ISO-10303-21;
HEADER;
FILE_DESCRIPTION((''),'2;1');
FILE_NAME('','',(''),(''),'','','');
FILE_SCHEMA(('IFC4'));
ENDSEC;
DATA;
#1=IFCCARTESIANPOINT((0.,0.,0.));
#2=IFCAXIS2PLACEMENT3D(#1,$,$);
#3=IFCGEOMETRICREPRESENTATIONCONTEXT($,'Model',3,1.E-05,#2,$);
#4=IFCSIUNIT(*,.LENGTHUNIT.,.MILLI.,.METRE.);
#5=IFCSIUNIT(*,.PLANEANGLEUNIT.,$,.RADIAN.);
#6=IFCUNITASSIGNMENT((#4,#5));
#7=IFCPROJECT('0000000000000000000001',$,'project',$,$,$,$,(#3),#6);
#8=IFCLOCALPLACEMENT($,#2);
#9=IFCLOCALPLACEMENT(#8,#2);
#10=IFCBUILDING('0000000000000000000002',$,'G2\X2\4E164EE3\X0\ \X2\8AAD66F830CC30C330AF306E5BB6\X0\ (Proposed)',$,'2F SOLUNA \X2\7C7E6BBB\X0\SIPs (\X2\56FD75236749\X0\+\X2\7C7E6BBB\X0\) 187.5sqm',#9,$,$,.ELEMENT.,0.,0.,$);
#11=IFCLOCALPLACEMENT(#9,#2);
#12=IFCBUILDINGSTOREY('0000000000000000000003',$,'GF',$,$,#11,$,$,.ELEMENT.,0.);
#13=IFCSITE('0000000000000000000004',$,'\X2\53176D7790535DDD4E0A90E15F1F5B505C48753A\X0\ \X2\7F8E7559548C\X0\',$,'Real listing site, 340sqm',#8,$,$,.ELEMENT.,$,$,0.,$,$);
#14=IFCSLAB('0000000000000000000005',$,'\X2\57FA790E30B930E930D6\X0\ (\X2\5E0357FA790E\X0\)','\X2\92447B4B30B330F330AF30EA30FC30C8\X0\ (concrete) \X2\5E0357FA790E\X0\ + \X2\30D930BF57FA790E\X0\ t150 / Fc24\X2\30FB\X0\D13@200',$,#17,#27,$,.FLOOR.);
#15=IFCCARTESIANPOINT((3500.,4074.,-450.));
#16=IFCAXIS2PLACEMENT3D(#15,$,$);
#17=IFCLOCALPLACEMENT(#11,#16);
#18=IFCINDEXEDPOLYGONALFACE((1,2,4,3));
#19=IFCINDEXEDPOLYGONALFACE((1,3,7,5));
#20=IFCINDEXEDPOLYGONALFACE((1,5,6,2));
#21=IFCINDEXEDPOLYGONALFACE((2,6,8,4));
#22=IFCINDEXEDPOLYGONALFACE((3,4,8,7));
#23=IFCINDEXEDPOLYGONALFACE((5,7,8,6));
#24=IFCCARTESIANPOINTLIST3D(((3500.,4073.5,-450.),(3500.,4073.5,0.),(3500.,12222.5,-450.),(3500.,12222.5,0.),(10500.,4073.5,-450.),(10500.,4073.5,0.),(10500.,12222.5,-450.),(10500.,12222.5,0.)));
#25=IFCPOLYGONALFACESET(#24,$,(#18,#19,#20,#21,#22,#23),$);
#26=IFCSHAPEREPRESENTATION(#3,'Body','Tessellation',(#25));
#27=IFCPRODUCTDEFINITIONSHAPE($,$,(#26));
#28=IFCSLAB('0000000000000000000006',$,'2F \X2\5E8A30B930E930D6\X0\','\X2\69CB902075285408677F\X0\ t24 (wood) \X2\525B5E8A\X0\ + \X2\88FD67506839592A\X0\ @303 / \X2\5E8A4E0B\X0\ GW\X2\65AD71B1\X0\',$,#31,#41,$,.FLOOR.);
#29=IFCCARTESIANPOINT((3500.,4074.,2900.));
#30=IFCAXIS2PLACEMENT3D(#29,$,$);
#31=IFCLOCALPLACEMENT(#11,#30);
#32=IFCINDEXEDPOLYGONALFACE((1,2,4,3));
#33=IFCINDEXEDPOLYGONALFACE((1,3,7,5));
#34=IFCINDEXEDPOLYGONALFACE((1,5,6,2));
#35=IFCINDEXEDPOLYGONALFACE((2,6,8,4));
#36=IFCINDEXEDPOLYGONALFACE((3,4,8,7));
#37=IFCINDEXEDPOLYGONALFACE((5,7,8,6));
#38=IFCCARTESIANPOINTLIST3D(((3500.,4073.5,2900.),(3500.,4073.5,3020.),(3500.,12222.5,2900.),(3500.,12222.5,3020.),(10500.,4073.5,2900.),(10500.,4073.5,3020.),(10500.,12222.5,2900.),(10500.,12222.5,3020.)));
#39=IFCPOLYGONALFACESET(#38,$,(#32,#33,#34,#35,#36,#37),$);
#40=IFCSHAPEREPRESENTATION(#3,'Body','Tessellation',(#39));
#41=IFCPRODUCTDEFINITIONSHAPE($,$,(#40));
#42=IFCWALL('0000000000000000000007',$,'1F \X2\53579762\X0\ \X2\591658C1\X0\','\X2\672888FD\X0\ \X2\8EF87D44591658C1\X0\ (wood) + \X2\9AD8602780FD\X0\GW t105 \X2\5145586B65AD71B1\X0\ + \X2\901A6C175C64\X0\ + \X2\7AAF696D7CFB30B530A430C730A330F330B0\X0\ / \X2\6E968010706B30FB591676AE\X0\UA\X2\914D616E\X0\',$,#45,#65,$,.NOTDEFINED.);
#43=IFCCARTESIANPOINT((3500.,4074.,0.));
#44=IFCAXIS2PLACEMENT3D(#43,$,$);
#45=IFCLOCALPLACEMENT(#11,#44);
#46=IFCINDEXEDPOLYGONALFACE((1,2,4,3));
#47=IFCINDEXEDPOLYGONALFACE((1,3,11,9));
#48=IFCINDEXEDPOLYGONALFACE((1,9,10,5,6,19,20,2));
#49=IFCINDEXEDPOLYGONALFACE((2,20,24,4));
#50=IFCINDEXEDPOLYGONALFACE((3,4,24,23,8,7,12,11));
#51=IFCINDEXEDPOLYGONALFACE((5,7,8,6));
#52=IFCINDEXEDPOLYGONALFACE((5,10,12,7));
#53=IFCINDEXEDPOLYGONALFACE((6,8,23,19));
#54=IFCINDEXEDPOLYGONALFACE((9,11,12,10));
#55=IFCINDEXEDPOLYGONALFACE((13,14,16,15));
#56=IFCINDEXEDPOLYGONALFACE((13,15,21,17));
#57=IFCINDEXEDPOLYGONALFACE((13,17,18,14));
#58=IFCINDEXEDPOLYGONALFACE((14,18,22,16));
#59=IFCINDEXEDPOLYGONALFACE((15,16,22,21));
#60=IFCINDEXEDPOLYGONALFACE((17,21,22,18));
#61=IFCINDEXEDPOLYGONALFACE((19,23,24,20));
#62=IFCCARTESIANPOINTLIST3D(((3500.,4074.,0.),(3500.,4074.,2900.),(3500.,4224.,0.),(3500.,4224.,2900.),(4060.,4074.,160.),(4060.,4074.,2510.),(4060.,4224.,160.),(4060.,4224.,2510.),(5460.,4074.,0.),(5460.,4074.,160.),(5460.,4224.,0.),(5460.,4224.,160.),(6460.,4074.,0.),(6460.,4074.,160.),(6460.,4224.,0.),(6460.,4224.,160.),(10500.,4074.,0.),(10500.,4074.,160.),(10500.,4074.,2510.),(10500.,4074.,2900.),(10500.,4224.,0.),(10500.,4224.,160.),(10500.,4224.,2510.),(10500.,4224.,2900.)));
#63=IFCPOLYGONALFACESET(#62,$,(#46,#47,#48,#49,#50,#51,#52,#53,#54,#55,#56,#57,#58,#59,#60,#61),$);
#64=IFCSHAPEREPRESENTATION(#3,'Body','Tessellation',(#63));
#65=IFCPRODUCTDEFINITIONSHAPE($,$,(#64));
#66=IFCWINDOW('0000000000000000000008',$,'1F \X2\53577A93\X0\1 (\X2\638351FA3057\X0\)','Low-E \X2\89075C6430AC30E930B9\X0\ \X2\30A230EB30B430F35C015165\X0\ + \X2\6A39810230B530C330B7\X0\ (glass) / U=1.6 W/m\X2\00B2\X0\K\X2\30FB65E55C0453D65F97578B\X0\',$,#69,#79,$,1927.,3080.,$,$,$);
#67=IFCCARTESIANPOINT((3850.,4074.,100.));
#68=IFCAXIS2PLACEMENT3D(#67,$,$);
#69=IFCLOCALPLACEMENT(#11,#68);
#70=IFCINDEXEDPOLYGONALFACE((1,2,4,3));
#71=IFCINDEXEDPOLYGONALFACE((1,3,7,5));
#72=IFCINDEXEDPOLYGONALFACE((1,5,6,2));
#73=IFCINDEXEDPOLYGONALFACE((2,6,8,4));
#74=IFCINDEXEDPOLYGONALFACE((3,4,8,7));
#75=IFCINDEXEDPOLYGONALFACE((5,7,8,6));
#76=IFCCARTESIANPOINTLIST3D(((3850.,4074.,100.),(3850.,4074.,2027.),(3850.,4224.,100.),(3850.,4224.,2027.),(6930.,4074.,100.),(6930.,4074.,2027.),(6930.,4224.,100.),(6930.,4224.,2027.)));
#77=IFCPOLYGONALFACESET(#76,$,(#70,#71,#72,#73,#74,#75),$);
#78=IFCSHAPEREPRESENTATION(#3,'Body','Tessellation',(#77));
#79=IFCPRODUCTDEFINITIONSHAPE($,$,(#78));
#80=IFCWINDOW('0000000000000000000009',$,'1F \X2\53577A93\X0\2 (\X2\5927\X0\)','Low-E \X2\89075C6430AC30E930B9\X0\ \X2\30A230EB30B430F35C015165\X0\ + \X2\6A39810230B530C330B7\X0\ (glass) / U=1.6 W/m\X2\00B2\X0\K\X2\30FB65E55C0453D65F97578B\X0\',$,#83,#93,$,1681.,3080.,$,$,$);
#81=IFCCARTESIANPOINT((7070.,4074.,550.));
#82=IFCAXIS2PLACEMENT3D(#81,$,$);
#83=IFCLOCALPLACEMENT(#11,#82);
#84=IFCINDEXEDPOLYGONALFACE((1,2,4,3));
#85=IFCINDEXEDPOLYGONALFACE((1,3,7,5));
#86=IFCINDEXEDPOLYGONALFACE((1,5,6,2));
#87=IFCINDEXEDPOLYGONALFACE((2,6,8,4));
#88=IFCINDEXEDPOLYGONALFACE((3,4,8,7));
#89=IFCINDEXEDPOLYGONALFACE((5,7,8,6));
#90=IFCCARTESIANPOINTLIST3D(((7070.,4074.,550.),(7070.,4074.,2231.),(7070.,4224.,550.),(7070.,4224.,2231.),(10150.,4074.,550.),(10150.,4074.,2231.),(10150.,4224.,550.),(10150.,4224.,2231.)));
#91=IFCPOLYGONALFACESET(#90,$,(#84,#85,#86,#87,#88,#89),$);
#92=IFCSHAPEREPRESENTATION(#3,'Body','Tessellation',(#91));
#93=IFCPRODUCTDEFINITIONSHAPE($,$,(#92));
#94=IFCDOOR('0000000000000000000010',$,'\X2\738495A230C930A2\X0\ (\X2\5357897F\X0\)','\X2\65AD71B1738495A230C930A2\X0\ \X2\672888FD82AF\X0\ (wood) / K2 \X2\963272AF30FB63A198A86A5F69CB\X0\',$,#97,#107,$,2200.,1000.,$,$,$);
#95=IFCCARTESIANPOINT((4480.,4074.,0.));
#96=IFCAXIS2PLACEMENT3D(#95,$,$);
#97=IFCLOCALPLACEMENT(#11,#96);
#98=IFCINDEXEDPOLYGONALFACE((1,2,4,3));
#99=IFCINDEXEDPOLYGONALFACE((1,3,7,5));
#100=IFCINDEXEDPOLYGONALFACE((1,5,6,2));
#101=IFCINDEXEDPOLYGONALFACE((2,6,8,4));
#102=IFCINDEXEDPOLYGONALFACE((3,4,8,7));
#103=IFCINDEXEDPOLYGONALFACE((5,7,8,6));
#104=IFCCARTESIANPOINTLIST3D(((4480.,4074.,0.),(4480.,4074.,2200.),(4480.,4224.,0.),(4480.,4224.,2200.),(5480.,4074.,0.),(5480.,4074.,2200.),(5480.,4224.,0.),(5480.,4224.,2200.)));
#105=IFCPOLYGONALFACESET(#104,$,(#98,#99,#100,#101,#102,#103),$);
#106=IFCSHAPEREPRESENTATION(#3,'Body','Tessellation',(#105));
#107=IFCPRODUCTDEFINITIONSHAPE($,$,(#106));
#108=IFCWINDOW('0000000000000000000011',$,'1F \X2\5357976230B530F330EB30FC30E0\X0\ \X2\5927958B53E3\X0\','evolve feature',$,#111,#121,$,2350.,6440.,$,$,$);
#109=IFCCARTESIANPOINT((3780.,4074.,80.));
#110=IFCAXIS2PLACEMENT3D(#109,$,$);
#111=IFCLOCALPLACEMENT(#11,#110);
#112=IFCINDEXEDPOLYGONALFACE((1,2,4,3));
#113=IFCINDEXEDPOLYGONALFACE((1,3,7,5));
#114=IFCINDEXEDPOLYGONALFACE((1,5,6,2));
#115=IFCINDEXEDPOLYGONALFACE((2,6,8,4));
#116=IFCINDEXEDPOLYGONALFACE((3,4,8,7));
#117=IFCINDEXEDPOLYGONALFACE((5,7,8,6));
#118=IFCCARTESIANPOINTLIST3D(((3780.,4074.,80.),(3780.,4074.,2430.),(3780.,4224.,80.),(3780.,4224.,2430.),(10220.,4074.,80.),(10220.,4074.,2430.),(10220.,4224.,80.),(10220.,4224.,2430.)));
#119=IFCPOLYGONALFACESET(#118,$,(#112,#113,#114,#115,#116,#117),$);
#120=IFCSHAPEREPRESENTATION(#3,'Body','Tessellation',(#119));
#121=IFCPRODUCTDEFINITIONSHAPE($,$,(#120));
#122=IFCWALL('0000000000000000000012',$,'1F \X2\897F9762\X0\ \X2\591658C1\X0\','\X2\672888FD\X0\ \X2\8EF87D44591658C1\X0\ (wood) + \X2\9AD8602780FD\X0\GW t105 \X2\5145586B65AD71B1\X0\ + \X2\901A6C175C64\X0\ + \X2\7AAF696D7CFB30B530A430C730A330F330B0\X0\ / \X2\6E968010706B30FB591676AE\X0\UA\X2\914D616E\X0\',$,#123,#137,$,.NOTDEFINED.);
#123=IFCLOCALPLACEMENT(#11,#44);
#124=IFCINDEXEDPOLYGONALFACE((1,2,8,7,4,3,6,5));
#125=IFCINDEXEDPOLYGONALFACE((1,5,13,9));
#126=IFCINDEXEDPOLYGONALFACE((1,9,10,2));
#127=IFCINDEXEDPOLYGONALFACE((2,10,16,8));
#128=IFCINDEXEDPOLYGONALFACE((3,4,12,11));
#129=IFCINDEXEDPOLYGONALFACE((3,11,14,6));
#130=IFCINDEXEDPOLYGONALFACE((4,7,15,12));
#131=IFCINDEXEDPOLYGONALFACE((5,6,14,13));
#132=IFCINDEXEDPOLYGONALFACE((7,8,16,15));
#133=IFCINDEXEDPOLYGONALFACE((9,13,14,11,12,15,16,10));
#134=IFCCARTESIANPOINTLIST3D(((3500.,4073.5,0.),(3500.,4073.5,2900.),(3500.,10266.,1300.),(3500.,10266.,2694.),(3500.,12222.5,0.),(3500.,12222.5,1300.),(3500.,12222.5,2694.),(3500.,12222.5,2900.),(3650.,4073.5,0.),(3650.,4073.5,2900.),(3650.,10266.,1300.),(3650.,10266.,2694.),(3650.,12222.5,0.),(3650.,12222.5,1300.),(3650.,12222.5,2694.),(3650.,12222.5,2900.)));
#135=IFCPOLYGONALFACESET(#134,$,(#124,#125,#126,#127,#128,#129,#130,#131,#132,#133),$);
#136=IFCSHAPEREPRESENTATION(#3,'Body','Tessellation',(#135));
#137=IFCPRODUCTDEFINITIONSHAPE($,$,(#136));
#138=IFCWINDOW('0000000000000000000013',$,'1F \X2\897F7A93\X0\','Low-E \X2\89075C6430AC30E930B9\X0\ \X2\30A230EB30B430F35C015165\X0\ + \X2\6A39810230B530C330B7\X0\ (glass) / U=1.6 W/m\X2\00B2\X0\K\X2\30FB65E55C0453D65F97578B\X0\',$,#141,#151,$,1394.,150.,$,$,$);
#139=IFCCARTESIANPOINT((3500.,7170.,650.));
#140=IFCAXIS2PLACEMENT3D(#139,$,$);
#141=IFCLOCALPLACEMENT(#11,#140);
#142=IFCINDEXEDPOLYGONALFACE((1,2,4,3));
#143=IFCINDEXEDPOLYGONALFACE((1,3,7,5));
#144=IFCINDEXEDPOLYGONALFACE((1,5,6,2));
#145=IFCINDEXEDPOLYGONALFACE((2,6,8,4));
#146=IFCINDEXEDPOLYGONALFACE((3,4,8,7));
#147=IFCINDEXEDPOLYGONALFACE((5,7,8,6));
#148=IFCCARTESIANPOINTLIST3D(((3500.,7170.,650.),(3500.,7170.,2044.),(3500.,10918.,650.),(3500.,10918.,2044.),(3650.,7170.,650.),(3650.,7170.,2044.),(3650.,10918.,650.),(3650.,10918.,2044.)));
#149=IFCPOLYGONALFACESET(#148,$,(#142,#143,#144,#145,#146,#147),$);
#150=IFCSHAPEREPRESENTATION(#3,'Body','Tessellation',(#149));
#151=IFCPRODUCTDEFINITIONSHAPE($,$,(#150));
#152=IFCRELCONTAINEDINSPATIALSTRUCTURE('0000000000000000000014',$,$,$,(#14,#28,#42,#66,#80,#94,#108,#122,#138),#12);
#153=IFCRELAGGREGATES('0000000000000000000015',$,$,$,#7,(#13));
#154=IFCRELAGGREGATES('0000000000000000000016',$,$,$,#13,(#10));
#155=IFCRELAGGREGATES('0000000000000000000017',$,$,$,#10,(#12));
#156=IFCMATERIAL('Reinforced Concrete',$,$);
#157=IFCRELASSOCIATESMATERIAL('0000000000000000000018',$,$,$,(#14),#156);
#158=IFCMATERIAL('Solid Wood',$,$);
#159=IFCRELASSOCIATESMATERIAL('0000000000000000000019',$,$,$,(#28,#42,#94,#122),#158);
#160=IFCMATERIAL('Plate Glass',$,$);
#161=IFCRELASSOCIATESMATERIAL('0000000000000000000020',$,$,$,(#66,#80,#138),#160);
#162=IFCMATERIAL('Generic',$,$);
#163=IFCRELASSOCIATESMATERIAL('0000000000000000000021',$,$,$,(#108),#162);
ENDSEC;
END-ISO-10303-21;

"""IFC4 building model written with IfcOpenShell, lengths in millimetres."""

from ifc_helpers import new_model, si_unit, frame, frame_2d, origin, place, context, project, spatial, rectangle, extrude, material, element, fill, save


model = new_model("IFC4")

# Units and contexts
model_context = context("Model", 3, precision=1e-05, world=origin())
ifc_project = project(units=[si_unit("LENGTHUNIT", "METRE", prefix="MILLI"), si_unit("PLANEANGLEUNIT", "RADIAN")], contexts=[model_context])

# Site, building, storey
site_placement = place(None, origin())
site = spatial("IfcSite", under=ifc_project, at=site_placement, Name="北海道川上郡弟子屈町 美留和", ObjectType="Real listing site, 340sqm", CompositionType="ELEMENT", RefElevation=0.0)
building_placement = place(site_placement, origin())
building = spatial("IfcBuilding", under=site, at=building_placement, Name="G2世代 読書ヌックの家 (Proposed)", ObjectType="2F SOLUNA 籾殻SIPs (国産杉+籾殻) 187.5sqm", CompositionType="ELEMENT", ElevationOfRefHeight=0.0, ElevationOfTerrain=0.0)
storey_placement = place(building_placement, origin())
storey = spatial("IfcBuildingStorey", under=building, at=storey_placement, Name="GF", CompositionType="ELEMENT", Elevation=0.0)

# Slabs
ifc_material_1 = material(Name="Reinforced Concrete")
slab_1_placement = place(storey_placement, frame((3500.0, 4074.0, -450.0)))
element("IfcSlab", 1, at=slab_1_placement, inside=storey, material=ifc_material_1, Name="基礎スラブ (布基礎)", Description="鉄筋コンクリート (concrete) 布基礎 + ベタ基礎 t150 / Fc24・D13@200", PredefinedType="FLOOR", context=model_context, shape_type="SweptSolid", body=[
    extrude(rectangle(XDim=7000.0, YDim=8149.0, at=frame_2d((3500.0, 4074.0))), frame((3500.0, 4074.0, -450.0)), (0.0, 0.0, 1.0), 450.0),
])
ifc_material_2 = material(Name="Solid Wood")
slab_2_placement = place(storey_placement, frame((3500.0, 4074.0, 2900.0)))
element("IfcSlab", 2, at=slab_2_placement, inside=storey, material=ifc_material_2, Name="2F 床スラブ", Description="構造用合板 t24 (wood) 剛床 + 製材根太 @303 / 床下 GW断熱", PredefinedType="FLOOR", context=model_context, shape_type="SweptSolid", body=[
    extrude(rectangle(XDim=7000.0, YDim=8149.0, at=frame_2d((3500.0, 4074.0))), frame((3500.0, 4074.0, 2900.0)), (0.0, 0.0, 1.0), 120.0),
])
ifc_material_3 = material(Name="Generic")

# Wall, openings, windows, door
wall_1_placement = place(storey_placement, frame((3500.0, 4074.0, 0.0)))
wall_1 = element("IfcWall", 3, at=wall_1_placement, inside=storey, material=ifc_material_2, Name="1F 南面 外壁", Description="木製 軸組外壁 (wood) + 高性能GW t105 充填断熱 + 通気層 + 窯業系サイディング / 準耐火・外皮UA配慮", PredefinedType="NOTDEFINED", context=model_context, shape_type="SweptSolid", body=[
    extrude(rectangle(XDim=7000.0, YDim=150.0, at=frame_2d((3500.0, 75.0))), frame((3500.0, 4074.0, 0.0)), (0.0, 0.0, 1.0), 2900.0),
])
opening_1_placement = place(storey_placement, frame((3850.0, 4074.0, 100.0)))
opening_1 = element("IfcOpeningElement", 4, at=opening_1_placement, cuts=wall_1, PredefinedType="NOTDEFINED", context=model_context, shape_type="SweptSolid", body=[
    extrude(rectangle(XDim=3080.0, YDim=150.0, at=frame_2d((1540.0, 75.0))), frame((3850.0, 4074.0, 100.0)), (0.0, 0.0, 1.0), 1927.0),
])
opening_2_placement = place(storey_placement, frame((7070.0, 4074.0, 550.0)))
opening_2 = element("IfcOpeningElement", 5, at=opening_2_placement, cuts=wall_1, PredefinedType="NOTDEFINED", context=model_context, shape_type="SweptSolid", body=[
    extrude(rectangle(XDim=3080.0, YDim=150.0, at=frame_2d((1540.0, 75.0))), frame((7070.0, 4074.0, 550.0)), (0.0, 0.0, 1.0), 1681.0),
])
opening_3_placement = place(storey_placement, frame((4480.0, 4074.0, 0.0)))
opening_3 = element("IfcOpeningElement", 6, at=opening_3_placement, cuts=wall_1, PredefinedType="NOTDEFINED", context=model_context, shape_type="SweptSolid", body=[
    extrude(rectangle(XDim=1000.0, YDim=150.0, at=frame_2d((500.0, 75.0))), frame((4480.0, 4074.0, 0.0)), (0.0, 0.0, 1.0), 2200.0),
])
opening_4_placement = place(storey_placement, frame((3780.0, 4074.0, 80.0)))
opening_4 = element("IfcOpeningElement", 7, at=opening_4_placement, cuts=wall_1, PredefinedType="NOTDEFINED", context=model_context, shape_type="SweptSolid", body=[
    extrude(rectangle(XDim=6440.0, YDim=150.0, at=frame_2d((3220.0, 75.0))), frame((3780.0, 4074.0, 80.0)), (0.0, 0.0, 1.0), 2350.0),
])
ifc_material_4 = material(Name="Plate Glass")
window_1_placement = place(storey_placement, frame((3850.0, 4074.0, 100.0)))
window_1 = element("IfcWindow", 8, at=window_1_placement, inside=storey, material=ifc_material_4, Name="1F 南窓1 (掃出し)", Description="Low-E 複層ガラス アルゴン封入 + 樹脂サッシ (glass) / U=1.6 W/m²K・日射取得型", OverallHeight=1927.0, OverallWidth=3080.0, context=model_context, shape_type="SweptSolid", body=[
    extrude(rectangle(XDim=3080.0, YDim=150.0, at=frame_2d((1540.0, 75.0))), frame((3850.0, 4074.0, 100.0)), (0.0, 0.0, 1.0), 1927.0),
])
fill(opening_1, window_1)
window_2_placement = place(storey_placement, frame((7070.0, 4074.0, 550.0)))
window_2 = element("IfcWindow", 9, at=window_2_placement, inside=storey, material=ifc_material_4, Name="1F 南窓2 (大)", Description="Low-E 複層ガラス アルゴン封入 + 樹脂サッシ (glass) / U=1.6 W/m²K・日射取得型", OverallHeight=1681.0, OverallWidth=3080.0, context=model_context, shape_type="SweptSolid", body=[
    extrude(rectangle(XDim=3080.0, YDim=150.0, at=frame_2d((1540.0, 75.0))), frame((7070.0, 4074.0, 550.0)), (0.0, 0.0, 1.0), 1681.0),
])
fill(opening_2, window_2)
door_placement = place(storey_placement, frame((4480.0, 4074.0, 0.0)))
door = element("IfcDoor", 10, at=door_placement, inside=storey, material=ifc_material_2, Name="玄関ドア (南西)", Description="断熱玄関ドア 木製芯 (wood) / K2 防犯・採風機構", OverallHeight=2200.0, OverallWidth=1000.0, context=model_context, shape_type="SweptSolid", body=[
    extrude(rectangle(XDim=1000.0, YDim=150.0, at=frame_2d((500.0, 75.0))), frame((4480.0, 4074.0, 0.0)), (0.0, 0.0, 1.0), 2200.0),
])
fill(opening_3, door)
window_3_placement = place(storey_placement, frame((3780.0, 4074.0, 80.0)))
window_3 = element("IfcWindow", 11, at=window_3_placement, inside=storey, material=ifc_material_3, Name="1F 南面サンルーム 大開口", Description="evolve feature", OverallHeight=2350.0, OverallWidth=6440.0, context=model_context, shape_type="SweptSolid", body=[
    extrude(rectangle(XDim=6440.0, YDim=150.0, at=frame_2d((3220.0, 75.0))), frame((3780.0, 4074.0, 80.0)), (0.0, 0.0, 1.0), 2350.0),
])
fill(opening_4, window_3)

# Wall, opening, window
wall_2_placement = place(storey_placement, frame((3500.0, 4074.0, 0.0)))
wall_2 = element("IfcWall", 12, at=wall_2_placement, inside=storey, material=ifc_material_2, Name="1F 西面 外壁", Description="木製 軸組外壁 (wood) + 高性能GW t105 充填断熱 + 通気層 + 窯業系サイディング / 準耐火・外皮UA配慮", PredefinedType="NOTDEFINED", context=model_context, shape_type="SweptSolid", body=[
    extrude(rectangle(XDim=150.0, YDim=8149.0, at=frame_2d((75.0, 4074.0))), frame((3500.0, 4074.0, 0.0)), (0.0, 0.0, 1.0), 2900.0),
])
opening_5_placement = place(storey_placement, frame((3500.0, 7170.0, 650.0)))
opening_5 = element("IfcOpeningElement", 13, at=opening_5_placement, cuts=wall_2, PredefinedType="NOTDEFINED", context=model_context, shape_type="SweptSolid", body=[
    extrude(rectangle(XDim=150.0, YDim=3748.0, at=frame_2d((75.0, 1874.0))), frame((3500.0, 7170.0, 650.0)), (0.0, 0.0, 1.0), 1394.0),
])
window_4_placement = place(storey_placement, frame((3500.0, 7170.0, 650.0)))
window_4 = element("IfcWindow", 14, at=window_4_placement, inside=storey, material=ifc_material_4, Name="1F 西窓", Description="Low-E 複層ガラス アルゴン封入 + 樹脂サッシ (glass) / U=1.6 W/m²K・日射取得型", OverallHeight=1394.0, OverallWidth=150.0, context=model_context, shape_type="SweptSolid", body=[
    extrude(rectangle(XDim=150.0, YDim=3748.0, at=frame_2d((75.0, 1874.0))), frame((3500.0, 7170.0, 650.0)), (0.0, 0.0, 1.0), 1394.0),
])
fill(opening_5, window_4)

save(model, "model.ifc")
